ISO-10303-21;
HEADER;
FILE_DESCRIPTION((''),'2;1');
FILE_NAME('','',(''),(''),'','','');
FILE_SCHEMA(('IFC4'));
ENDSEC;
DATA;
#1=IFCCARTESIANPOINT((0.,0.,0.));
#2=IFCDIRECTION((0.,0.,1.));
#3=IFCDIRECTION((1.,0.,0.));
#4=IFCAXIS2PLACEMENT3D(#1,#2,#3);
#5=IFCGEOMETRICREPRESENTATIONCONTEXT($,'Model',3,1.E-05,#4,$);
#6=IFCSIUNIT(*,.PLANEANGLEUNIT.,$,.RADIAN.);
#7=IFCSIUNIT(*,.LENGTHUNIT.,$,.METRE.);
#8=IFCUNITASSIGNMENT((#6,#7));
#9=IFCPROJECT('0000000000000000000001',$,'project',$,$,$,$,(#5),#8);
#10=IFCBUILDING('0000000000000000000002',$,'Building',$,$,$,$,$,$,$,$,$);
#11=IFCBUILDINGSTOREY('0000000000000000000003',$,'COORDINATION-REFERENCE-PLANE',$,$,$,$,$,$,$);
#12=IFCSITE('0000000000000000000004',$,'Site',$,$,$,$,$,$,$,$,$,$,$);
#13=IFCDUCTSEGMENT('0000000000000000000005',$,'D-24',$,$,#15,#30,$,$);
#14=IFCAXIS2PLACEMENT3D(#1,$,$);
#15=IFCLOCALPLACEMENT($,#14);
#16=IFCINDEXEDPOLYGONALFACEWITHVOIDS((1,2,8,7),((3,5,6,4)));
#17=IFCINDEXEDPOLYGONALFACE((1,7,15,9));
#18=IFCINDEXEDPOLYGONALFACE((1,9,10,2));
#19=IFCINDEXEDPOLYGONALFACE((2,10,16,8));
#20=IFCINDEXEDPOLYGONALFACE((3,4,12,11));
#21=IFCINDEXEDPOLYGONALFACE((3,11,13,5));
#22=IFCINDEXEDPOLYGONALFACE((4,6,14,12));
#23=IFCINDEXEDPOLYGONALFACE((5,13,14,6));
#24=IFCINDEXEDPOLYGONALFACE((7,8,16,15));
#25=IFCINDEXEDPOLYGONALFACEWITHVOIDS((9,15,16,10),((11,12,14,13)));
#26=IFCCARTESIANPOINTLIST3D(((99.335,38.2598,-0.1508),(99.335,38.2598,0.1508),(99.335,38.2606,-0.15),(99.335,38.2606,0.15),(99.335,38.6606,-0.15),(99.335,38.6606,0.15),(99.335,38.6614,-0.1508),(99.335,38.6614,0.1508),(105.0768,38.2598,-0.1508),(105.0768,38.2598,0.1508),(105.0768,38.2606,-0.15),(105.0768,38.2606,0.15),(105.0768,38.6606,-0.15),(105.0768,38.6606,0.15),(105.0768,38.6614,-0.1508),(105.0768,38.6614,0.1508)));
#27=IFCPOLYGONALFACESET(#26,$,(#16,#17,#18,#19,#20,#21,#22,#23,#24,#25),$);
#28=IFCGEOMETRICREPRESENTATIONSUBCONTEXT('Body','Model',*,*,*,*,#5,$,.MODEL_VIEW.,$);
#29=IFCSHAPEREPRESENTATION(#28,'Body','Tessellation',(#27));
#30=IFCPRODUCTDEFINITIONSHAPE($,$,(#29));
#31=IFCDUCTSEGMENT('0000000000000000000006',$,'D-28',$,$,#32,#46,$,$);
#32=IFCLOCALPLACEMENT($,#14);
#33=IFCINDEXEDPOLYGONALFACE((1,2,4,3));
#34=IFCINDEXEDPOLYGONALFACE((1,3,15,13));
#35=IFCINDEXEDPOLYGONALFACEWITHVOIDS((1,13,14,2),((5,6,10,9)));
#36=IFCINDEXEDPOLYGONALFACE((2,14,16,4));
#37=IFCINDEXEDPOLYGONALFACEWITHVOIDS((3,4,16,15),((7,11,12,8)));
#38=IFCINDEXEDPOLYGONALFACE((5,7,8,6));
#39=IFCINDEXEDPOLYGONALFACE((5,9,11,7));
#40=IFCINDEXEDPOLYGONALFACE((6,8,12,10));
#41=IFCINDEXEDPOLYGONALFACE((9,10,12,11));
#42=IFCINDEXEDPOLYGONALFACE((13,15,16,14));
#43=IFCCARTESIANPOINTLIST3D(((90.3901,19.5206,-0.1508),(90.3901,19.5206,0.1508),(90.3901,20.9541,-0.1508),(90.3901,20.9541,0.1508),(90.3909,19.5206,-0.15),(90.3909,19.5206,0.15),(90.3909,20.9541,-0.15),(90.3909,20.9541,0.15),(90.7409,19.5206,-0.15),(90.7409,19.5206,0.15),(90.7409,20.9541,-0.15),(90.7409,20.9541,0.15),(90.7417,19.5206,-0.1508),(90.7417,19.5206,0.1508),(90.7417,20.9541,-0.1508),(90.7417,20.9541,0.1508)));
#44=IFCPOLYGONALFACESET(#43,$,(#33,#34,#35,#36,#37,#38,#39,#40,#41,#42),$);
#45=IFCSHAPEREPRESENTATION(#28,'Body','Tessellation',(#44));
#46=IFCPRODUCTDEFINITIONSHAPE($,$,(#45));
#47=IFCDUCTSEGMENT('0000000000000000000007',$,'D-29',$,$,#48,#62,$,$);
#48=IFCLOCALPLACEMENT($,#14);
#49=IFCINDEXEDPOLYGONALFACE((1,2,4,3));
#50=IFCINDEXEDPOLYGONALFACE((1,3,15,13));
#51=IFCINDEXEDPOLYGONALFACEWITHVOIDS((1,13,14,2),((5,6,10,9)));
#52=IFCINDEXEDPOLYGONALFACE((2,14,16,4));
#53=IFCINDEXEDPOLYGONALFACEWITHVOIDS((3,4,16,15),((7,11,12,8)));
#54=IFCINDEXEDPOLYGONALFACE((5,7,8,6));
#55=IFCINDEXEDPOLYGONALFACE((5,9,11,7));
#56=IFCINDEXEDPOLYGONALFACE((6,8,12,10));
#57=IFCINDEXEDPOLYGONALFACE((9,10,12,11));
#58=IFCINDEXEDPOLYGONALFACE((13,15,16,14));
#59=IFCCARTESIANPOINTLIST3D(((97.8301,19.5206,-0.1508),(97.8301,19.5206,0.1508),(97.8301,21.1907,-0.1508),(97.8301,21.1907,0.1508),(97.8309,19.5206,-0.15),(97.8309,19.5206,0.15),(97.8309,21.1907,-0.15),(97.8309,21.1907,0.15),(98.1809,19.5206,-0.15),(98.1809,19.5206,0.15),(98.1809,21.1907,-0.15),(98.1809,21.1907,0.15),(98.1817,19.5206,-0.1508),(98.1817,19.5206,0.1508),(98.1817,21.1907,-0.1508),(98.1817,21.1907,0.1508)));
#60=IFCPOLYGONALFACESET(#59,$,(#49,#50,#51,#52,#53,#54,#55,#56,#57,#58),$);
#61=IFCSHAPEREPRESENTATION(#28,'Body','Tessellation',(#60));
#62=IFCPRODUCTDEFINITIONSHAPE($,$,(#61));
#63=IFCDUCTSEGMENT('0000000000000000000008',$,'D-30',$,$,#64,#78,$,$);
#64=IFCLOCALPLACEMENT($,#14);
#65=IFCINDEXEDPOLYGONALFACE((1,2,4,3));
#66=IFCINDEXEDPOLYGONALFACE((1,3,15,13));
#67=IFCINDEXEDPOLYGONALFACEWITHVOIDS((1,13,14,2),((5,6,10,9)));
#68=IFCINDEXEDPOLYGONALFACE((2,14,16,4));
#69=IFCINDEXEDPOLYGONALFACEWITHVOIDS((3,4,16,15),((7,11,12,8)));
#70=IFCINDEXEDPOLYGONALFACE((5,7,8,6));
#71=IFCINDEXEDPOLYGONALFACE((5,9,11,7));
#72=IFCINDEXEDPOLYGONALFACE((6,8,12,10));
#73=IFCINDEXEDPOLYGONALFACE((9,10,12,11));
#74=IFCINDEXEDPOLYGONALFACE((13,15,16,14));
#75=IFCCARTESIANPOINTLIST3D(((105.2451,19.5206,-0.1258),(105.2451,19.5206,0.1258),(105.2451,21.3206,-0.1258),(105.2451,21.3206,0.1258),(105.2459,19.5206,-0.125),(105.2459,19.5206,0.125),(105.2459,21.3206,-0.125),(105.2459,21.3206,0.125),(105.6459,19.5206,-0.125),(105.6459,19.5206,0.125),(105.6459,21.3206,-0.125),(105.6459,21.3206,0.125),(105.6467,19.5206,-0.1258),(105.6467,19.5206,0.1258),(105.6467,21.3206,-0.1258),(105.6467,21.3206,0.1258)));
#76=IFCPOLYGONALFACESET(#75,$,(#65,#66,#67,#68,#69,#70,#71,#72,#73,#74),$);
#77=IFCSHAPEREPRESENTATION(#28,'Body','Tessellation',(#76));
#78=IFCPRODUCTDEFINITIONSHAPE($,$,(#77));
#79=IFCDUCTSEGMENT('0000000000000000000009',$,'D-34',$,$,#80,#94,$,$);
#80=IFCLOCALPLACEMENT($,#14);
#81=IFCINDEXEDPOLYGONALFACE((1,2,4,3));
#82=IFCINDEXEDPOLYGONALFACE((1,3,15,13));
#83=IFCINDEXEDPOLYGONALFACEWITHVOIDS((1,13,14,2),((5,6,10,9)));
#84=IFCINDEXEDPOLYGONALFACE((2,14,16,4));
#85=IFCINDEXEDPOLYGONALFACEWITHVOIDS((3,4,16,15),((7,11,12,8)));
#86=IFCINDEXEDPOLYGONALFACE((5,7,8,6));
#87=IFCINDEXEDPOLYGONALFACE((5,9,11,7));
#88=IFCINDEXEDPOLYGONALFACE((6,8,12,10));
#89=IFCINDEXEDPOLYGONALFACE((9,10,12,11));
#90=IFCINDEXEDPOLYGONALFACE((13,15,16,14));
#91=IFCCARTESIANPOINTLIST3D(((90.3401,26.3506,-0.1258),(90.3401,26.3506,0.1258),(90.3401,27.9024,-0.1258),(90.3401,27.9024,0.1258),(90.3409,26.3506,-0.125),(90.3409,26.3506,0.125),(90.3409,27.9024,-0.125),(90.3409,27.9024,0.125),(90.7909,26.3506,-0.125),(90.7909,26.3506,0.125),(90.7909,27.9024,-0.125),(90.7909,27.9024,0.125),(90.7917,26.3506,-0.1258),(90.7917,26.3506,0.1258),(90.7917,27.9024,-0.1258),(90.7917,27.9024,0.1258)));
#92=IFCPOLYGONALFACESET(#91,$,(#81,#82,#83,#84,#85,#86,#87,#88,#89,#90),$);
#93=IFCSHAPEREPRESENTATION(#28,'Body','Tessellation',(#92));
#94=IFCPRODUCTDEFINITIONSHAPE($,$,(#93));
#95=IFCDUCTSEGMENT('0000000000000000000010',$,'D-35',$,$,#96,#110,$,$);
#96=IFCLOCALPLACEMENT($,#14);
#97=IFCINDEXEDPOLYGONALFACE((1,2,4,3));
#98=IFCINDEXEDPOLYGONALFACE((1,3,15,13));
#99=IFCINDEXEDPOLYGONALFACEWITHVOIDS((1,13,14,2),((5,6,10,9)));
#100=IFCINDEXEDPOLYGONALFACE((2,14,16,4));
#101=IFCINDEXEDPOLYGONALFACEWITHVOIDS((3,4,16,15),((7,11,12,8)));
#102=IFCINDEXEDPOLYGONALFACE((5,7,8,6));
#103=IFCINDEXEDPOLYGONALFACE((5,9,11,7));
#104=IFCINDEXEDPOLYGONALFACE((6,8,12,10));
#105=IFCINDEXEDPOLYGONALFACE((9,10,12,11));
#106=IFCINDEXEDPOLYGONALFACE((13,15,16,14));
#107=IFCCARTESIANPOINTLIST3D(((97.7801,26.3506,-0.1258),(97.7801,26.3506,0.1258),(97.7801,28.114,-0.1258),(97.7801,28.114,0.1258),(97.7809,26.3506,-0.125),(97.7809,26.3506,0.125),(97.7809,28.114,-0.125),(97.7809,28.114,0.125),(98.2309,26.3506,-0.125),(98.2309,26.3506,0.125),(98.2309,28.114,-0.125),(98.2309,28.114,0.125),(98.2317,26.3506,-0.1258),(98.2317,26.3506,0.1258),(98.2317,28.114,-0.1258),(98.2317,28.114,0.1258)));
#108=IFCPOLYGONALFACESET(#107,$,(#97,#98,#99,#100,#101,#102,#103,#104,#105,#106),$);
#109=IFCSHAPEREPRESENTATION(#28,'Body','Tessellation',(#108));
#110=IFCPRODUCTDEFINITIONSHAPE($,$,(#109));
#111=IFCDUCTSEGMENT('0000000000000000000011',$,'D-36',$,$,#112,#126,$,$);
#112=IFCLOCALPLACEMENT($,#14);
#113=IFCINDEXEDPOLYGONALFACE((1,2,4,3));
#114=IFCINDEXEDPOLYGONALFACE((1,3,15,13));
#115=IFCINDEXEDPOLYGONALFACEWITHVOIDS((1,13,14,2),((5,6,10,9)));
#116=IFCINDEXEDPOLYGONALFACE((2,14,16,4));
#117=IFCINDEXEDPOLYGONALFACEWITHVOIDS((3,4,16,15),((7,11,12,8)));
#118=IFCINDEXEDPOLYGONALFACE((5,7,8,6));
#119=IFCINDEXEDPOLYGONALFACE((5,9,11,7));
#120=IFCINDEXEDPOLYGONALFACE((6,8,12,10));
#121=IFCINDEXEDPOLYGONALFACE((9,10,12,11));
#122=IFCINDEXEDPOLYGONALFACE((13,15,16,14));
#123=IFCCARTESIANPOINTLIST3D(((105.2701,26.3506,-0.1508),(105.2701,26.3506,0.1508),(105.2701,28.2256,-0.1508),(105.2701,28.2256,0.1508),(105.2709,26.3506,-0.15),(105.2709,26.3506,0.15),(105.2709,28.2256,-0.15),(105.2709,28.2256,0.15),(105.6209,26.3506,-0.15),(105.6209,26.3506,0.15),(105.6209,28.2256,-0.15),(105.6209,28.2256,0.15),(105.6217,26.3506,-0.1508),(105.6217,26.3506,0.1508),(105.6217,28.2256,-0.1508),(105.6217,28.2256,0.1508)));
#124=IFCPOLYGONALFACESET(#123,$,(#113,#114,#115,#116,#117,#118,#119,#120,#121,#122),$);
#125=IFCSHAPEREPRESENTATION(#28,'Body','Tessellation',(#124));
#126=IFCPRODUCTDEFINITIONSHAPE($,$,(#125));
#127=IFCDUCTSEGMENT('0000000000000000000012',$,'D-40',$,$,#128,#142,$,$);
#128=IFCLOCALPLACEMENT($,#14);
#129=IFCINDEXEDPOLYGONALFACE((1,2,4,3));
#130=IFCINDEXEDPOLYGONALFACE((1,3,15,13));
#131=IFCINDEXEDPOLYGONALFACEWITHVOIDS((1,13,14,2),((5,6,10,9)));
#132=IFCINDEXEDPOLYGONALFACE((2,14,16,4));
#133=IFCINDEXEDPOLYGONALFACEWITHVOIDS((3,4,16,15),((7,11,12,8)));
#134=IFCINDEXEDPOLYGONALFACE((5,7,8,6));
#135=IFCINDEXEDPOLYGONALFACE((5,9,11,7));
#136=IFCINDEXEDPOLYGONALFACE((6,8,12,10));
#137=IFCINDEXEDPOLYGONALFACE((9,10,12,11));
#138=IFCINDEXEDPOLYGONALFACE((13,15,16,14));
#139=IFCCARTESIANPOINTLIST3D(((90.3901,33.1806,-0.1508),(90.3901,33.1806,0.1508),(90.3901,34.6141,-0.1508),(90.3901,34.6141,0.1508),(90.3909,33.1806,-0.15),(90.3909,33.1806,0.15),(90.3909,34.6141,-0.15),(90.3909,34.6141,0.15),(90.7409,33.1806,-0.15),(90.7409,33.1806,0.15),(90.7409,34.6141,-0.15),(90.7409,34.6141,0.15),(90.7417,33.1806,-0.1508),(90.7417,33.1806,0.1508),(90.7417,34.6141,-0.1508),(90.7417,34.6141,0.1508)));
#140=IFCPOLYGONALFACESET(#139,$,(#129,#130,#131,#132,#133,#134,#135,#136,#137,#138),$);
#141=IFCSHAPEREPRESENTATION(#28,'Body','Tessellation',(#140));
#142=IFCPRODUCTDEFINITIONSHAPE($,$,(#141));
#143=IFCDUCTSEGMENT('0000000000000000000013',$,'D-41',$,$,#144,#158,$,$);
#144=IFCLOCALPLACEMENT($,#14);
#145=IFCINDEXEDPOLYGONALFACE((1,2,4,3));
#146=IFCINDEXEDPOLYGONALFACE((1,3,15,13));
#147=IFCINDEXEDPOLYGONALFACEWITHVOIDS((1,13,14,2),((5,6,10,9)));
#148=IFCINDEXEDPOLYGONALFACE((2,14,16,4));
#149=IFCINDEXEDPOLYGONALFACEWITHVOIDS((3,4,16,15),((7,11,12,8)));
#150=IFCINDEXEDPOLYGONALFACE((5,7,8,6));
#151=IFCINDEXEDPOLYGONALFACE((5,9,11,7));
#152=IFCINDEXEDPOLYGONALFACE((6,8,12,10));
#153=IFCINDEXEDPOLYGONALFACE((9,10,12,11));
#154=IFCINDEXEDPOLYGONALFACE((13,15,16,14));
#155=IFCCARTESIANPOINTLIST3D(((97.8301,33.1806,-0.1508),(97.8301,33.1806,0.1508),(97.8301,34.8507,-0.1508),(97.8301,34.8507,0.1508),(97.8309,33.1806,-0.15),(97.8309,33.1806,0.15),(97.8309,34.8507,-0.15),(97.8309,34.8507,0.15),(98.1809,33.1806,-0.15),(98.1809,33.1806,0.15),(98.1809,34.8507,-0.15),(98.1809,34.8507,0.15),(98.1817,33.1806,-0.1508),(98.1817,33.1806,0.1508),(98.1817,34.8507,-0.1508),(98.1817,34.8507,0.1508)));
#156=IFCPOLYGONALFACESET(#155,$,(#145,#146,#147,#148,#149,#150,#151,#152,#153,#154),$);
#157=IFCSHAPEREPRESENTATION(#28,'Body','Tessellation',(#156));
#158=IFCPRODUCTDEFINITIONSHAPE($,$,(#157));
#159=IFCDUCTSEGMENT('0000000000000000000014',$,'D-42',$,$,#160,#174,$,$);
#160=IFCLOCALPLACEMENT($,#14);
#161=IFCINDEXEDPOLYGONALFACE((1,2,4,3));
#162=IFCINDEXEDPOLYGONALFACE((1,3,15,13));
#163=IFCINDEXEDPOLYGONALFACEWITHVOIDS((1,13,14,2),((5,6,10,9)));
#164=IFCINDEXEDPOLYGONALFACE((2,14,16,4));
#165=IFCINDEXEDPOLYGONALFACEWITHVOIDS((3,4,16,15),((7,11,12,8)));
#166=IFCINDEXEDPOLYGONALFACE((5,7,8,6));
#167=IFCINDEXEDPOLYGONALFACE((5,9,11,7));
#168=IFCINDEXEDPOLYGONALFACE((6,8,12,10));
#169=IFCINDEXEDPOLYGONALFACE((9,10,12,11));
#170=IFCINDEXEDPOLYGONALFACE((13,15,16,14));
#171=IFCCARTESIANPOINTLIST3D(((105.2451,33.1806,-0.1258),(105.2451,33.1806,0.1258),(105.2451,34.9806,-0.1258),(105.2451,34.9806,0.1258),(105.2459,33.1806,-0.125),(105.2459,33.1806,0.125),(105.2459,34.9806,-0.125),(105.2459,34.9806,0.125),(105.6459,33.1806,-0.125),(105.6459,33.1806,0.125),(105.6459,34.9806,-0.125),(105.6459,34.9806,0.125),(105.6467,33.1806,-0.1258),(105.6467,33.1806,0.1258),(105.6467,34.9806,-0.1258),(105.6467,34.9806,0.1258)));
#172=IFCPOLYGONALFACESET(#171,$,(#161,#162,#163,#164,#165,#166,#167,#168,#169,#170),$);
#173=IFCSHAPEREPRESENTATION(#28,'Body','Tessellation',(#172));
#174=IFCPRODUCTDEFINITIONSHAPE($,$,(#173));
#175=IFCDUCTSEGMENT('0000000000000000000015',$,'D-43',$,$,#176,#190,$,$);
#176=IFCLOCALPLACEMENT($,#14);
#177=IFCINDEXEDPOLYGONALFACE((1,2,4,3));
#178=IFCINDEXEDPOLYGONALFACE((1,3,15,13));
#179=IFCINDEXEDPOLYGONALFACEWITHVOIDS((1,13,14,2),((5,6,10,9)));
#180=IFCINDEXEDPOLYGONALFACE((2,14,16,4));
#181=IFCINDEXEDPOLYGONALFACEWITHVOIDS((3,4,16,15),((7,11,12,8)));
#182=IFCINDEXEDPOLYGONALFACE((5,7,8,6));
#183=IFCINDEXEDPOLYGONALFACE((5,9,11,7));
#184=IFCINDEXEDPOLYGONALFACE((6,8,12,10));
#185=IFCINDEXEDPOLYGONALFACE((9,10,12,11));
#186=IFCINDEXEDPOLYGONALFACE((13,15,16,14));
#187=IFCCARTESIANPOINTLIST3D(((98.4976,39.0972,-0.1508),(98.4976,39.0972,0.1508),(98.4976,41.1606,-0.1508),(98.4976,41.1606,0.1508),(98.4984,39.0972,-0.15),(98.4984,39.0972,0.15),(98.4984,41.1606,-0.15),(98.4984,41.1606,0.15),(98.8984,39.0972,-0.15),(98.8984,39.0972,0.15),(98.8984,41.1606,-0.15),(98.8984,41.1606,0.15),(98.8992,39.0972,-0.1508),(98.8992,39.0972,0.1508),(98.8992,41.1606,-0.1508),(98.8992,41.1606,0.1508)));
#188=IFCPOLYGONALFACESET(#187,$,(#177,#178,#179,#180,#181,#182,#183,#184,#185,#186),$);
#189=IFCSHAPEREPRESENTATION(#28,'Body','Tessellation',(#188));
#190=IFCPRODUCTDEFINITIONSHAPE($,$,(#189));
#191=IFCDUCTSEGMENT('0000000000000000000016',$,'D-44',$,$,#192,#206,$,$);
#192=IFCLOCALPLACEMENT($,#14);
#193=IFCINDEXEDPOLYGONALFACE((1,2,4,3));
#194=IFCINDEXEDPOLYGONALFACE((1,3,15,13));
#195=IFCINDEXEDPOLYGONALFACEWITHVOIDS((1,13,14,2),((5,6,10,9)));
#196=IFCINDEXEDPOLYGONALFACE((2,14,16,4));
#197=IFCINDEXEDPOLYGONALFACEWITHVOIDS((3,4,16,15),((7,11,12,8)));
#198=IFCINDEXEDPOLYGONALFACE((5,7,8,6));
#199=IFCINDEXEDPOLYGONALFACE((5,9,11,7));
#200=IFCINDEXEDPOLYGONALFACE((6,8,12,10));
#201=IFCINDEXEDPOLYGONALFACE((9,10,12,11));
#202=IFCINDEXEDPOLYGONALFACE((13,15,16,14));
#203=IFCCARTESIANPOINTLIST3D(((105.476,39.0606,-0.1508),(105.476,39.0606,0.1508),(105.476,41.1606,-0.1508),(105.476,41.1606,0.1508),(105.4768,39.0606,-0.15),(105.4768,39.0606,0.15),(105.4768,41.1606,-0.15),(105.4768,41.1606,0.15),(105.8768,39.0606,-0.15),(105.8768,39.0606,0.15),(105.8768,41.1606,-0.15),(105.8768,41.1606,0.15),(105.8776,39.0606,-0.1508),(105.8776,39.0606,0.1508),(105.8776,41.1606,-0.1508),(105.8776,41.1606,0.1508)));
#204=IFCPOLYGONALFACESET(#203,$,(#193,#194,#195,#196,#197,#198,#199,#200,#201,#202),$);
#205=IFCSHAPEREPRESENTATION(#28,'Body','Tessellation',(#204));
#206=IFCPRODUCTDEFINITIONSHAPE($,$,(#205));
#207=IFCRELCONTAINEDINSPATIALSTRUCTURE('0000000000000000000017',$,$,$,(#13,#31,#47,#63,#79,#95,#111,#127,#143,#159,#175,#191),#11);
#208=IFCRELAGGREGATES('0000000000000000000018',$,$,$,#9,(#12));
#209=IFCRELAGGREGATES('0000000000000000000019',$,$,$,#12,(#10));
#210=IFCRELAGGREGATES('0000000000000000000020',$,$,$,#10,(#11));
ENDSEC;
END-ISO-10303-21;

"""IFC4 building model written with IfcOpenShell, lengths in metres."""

from ifc_helpers import new_model, si_unit, frame, origin, origin_with_axes, place, context, subcontext, project, spatial, hollow_rectangle, extrude, element, save


model = new_model("IFC4")

# Units and contexts
model_context = context("Model", 3, precision=1e-05, world=origin_with_axes())
body_context = subcontext(model_context, "Body", "Model", "MODEL_VIEW")
ifc_project = project(units=[si_unit("PLANEANGLEUNIT", "RADIAN"), si_unit("LENGTHUNIT", "METRE")], contexts=[model_context])

# Site, building, storey
site = spatial("IfcSite", under=ifc_project, Name="Site")
building = spatial("IfcBuilding", under=site, Name="Building")
storey = spatial("IfcBuildingStorey", under=building, Name="COORDINATION-REFERENCE-PLANE")

# Duct segments
duct_segment_1_placement = place(None, frame((99.335, 38.4606, 0.0), z_axis=(1.0, 0.0, 0.0), x_axis=(0.0, 1.0, 0.0)))
element("IfcDuctSegment", 1, at=duct_segment_1_placement, inside=storey, Name="D-24", context=body_context, shape_type="SweptSolid", body=[
    extrude(hollow_rectangle(XDim=0.4016, YDim=0.3016, WallThickness=0.0008), origin(), (0.0, 0.0, 1.0), 5.7417),
])
duct_segment_2_placement = place(None, frame((90.5659, 19.5206, 0.0), z_axis=(0.0, 1.0, 0.0), x_axis=(1.0, 0.0, 0.0)))
element("IfcDuctSegment", 2, at=duct_segment_2_placement, inside=storey, Name="D-28", context=body_context, shape_type="SweptSolid", body=[
    extrude(hollow_rectangle(XDim=0.3516, YDim=0.3016, WallThickness=0.0008), origin(), (0.0, 0.0, 1.0), 1.4335),
])
duct_segment_3_placement = place(None, frame((98.0059, 19.5206, 0.0), z_axis=(0.0, 1.0, 0.0), x_axis=(1.0, 0.0, 0.0)))
element("IfcDuctSegment", 3, at=duct_segment_3_placement, inside=storey, Name="D-29", context=body_context, shape_type="SweptSolid", body=[
    extrude(hollow_rectangle(XDim=0.3516, YDim=0.3016, WallThickness=0.0008), origin(), (0.0, 0.0, 1.0), 1.6701),
])
duct_segment_4_placement = place(None, frame((105.4459, 19.5206, 0.0), z_axis=(0.0, 1.0, 0.0), x_axis=(1.0, 0.0, 0.0)))
element("IfcDuctSegment", 4, at=duct_segment_4_placement, inside=storey, Name="D-30", context=body_context, shape_type="SweptSolid", body=[
    extrude(hollow_rectangle(XDim=0.4016, YDim=0.2516, WallThickness=0.0008), origin(), (0.0, 0.0, 1.0), 1.8),
])
duct_segment_5_placement = place(None, frame((90.5659, 26.3506, 0.0), z_axis=(0.0, 1.0, 0.0), x_axis=(1.0, 0.0, 0.0)))
element("IfcDuctSegment", 5, at=duct_segment_5_placement, inside=storey, Name="D-34", context=body_context, shape_type="SweptSolid", body=[
    extrude(hollow_rectangle(XDim=0.4516, YDim=0.2516, WallThickness=0.0008), origin(), (0.0, 0.0, 1.0), 1.5518),
])
duct_segment_6_placement = place(None, frame((98.0059, 26.3506, 0.0), z_axis=(0.0, 1.0, 0.0), x_axis=(1.0, 0.0, 0.0)))
element("IfcDuctSegment", 6, at=duct_segment_6_placement, inside=storey, Name="D-35", context=body_context, shape_type="SweptSolid", body=[
    extrude(hollow_rectangle(XDim=0.4516, YDim=0.2516, WallThickness=0.0008), origin(), (0.0, 0.0, 1.0), 1.7634),
])
duct_segment_7_placement = place(None, frame((105.4459, 26.3506, 0.0), z_axis=(0.0, 1.0, 0.0), x_axis=(1.0, 0.0, 0.0)))
element("IfcDuctSegment", 7, at=duct_segment_7_placement, inside=storey, Name="D-36", context=body_context, shape_type="SweptSolid", body=[
    extrude(hollow_rectangle(XDim=0.3516, YDim=0.3016, WallThickness=0.0008), origin(), (0.0, 0.0, 1.0), 1.875),
])
duct_segment_8_placement = place(None, frame((90.5659, 33.1806, 0.0), z_axis=(0.0, 1.0, 0.0), x_axis=(1.0, 0.0, 0.0)))
element("IfcDuctSegment", 8, at=duct_segment_8_placement, inside=storey, Name="D-40", context=body_context, shape_type="SweptSolid", body=[
    extrude(hollow_rectangle(XDim=0.3516, YDim=0.3016, WallThickness=0.0008), origin(), (0.0, 0.0, 1.0), 1.4335),
])
duct_segment_9_placement = place(None, frame((98.0059, 33.1806, 0.0), z_axis=(0.0, 1.0, 0.0), x_axis=(1.0, 0.0, 0.0)))
element("IfcDuctSegment", 9, at=duct_segment_9_placement, inside=storey, Name="D-41", context=body_context, shape_type="SweptSolid", body=[
    extrude(hollow_rectangle(XDim=0.3516, YDim=0.3016, WallThickness=0.0008), origin(), (0.0, 0.0, 1.0), 1.6701),
])
duct_segment_10_placement = place(None, frame((105.4459, 33.1806, 0.0), z_axis=(0.0, 1.0, 0.0), x_axis=(1.0, 0.0, 0.0)))
element("IfcDuctSegment", 10, at=duct_segment_10_placement, inside=storey, Name="D-42", context=body_context, shape_type="SweptSolid", body=[
    extrude(hollow_rectangle(XDim=0.4016, YDim=0.2516, WallThickness=0.0008), origin(), (0.0, 0.0, 1.0), 1.8),
])
duct_segment_11_placement = place(None, frame((98.6984, 39.0972, 0.0), z_axis=(0.0, 1.0, 0.0), x_axis=(1.0, 0.0, 0.0)))
element("IfcDuctSegment", 11, at=duct_segment_11_placement, inside=storey, Name="D-43", context=body_context, shape_type="SweptSolid", body=[
    extrude(hollow_rectangle(XDim=0.4016, YDim=0.3016, WallThickness=0.0008), origin(), (0.0, 0.0, 1.0), 2.0634),
])
duct_segment_12_placement = place(None, frame((105.6768, 39.0606, 0.0), z_axis=(0.0, 1.0, 0.0), x_axis=(1.0, 0.0, 0.0)))
element("IfcDuctSegment", 12, at=duct_segment_12_placement, inside=storey, Name="D-44", context=body_context, shape_type="SweptSolid", body=[
    extrude(hollow_rectangle(XDim=0.4016, YDim=0.3016, WallThickness=0.0008), origin(), (0.0, 0.0, 1.0), 2.1),
])

save(model, "model.ifc")
